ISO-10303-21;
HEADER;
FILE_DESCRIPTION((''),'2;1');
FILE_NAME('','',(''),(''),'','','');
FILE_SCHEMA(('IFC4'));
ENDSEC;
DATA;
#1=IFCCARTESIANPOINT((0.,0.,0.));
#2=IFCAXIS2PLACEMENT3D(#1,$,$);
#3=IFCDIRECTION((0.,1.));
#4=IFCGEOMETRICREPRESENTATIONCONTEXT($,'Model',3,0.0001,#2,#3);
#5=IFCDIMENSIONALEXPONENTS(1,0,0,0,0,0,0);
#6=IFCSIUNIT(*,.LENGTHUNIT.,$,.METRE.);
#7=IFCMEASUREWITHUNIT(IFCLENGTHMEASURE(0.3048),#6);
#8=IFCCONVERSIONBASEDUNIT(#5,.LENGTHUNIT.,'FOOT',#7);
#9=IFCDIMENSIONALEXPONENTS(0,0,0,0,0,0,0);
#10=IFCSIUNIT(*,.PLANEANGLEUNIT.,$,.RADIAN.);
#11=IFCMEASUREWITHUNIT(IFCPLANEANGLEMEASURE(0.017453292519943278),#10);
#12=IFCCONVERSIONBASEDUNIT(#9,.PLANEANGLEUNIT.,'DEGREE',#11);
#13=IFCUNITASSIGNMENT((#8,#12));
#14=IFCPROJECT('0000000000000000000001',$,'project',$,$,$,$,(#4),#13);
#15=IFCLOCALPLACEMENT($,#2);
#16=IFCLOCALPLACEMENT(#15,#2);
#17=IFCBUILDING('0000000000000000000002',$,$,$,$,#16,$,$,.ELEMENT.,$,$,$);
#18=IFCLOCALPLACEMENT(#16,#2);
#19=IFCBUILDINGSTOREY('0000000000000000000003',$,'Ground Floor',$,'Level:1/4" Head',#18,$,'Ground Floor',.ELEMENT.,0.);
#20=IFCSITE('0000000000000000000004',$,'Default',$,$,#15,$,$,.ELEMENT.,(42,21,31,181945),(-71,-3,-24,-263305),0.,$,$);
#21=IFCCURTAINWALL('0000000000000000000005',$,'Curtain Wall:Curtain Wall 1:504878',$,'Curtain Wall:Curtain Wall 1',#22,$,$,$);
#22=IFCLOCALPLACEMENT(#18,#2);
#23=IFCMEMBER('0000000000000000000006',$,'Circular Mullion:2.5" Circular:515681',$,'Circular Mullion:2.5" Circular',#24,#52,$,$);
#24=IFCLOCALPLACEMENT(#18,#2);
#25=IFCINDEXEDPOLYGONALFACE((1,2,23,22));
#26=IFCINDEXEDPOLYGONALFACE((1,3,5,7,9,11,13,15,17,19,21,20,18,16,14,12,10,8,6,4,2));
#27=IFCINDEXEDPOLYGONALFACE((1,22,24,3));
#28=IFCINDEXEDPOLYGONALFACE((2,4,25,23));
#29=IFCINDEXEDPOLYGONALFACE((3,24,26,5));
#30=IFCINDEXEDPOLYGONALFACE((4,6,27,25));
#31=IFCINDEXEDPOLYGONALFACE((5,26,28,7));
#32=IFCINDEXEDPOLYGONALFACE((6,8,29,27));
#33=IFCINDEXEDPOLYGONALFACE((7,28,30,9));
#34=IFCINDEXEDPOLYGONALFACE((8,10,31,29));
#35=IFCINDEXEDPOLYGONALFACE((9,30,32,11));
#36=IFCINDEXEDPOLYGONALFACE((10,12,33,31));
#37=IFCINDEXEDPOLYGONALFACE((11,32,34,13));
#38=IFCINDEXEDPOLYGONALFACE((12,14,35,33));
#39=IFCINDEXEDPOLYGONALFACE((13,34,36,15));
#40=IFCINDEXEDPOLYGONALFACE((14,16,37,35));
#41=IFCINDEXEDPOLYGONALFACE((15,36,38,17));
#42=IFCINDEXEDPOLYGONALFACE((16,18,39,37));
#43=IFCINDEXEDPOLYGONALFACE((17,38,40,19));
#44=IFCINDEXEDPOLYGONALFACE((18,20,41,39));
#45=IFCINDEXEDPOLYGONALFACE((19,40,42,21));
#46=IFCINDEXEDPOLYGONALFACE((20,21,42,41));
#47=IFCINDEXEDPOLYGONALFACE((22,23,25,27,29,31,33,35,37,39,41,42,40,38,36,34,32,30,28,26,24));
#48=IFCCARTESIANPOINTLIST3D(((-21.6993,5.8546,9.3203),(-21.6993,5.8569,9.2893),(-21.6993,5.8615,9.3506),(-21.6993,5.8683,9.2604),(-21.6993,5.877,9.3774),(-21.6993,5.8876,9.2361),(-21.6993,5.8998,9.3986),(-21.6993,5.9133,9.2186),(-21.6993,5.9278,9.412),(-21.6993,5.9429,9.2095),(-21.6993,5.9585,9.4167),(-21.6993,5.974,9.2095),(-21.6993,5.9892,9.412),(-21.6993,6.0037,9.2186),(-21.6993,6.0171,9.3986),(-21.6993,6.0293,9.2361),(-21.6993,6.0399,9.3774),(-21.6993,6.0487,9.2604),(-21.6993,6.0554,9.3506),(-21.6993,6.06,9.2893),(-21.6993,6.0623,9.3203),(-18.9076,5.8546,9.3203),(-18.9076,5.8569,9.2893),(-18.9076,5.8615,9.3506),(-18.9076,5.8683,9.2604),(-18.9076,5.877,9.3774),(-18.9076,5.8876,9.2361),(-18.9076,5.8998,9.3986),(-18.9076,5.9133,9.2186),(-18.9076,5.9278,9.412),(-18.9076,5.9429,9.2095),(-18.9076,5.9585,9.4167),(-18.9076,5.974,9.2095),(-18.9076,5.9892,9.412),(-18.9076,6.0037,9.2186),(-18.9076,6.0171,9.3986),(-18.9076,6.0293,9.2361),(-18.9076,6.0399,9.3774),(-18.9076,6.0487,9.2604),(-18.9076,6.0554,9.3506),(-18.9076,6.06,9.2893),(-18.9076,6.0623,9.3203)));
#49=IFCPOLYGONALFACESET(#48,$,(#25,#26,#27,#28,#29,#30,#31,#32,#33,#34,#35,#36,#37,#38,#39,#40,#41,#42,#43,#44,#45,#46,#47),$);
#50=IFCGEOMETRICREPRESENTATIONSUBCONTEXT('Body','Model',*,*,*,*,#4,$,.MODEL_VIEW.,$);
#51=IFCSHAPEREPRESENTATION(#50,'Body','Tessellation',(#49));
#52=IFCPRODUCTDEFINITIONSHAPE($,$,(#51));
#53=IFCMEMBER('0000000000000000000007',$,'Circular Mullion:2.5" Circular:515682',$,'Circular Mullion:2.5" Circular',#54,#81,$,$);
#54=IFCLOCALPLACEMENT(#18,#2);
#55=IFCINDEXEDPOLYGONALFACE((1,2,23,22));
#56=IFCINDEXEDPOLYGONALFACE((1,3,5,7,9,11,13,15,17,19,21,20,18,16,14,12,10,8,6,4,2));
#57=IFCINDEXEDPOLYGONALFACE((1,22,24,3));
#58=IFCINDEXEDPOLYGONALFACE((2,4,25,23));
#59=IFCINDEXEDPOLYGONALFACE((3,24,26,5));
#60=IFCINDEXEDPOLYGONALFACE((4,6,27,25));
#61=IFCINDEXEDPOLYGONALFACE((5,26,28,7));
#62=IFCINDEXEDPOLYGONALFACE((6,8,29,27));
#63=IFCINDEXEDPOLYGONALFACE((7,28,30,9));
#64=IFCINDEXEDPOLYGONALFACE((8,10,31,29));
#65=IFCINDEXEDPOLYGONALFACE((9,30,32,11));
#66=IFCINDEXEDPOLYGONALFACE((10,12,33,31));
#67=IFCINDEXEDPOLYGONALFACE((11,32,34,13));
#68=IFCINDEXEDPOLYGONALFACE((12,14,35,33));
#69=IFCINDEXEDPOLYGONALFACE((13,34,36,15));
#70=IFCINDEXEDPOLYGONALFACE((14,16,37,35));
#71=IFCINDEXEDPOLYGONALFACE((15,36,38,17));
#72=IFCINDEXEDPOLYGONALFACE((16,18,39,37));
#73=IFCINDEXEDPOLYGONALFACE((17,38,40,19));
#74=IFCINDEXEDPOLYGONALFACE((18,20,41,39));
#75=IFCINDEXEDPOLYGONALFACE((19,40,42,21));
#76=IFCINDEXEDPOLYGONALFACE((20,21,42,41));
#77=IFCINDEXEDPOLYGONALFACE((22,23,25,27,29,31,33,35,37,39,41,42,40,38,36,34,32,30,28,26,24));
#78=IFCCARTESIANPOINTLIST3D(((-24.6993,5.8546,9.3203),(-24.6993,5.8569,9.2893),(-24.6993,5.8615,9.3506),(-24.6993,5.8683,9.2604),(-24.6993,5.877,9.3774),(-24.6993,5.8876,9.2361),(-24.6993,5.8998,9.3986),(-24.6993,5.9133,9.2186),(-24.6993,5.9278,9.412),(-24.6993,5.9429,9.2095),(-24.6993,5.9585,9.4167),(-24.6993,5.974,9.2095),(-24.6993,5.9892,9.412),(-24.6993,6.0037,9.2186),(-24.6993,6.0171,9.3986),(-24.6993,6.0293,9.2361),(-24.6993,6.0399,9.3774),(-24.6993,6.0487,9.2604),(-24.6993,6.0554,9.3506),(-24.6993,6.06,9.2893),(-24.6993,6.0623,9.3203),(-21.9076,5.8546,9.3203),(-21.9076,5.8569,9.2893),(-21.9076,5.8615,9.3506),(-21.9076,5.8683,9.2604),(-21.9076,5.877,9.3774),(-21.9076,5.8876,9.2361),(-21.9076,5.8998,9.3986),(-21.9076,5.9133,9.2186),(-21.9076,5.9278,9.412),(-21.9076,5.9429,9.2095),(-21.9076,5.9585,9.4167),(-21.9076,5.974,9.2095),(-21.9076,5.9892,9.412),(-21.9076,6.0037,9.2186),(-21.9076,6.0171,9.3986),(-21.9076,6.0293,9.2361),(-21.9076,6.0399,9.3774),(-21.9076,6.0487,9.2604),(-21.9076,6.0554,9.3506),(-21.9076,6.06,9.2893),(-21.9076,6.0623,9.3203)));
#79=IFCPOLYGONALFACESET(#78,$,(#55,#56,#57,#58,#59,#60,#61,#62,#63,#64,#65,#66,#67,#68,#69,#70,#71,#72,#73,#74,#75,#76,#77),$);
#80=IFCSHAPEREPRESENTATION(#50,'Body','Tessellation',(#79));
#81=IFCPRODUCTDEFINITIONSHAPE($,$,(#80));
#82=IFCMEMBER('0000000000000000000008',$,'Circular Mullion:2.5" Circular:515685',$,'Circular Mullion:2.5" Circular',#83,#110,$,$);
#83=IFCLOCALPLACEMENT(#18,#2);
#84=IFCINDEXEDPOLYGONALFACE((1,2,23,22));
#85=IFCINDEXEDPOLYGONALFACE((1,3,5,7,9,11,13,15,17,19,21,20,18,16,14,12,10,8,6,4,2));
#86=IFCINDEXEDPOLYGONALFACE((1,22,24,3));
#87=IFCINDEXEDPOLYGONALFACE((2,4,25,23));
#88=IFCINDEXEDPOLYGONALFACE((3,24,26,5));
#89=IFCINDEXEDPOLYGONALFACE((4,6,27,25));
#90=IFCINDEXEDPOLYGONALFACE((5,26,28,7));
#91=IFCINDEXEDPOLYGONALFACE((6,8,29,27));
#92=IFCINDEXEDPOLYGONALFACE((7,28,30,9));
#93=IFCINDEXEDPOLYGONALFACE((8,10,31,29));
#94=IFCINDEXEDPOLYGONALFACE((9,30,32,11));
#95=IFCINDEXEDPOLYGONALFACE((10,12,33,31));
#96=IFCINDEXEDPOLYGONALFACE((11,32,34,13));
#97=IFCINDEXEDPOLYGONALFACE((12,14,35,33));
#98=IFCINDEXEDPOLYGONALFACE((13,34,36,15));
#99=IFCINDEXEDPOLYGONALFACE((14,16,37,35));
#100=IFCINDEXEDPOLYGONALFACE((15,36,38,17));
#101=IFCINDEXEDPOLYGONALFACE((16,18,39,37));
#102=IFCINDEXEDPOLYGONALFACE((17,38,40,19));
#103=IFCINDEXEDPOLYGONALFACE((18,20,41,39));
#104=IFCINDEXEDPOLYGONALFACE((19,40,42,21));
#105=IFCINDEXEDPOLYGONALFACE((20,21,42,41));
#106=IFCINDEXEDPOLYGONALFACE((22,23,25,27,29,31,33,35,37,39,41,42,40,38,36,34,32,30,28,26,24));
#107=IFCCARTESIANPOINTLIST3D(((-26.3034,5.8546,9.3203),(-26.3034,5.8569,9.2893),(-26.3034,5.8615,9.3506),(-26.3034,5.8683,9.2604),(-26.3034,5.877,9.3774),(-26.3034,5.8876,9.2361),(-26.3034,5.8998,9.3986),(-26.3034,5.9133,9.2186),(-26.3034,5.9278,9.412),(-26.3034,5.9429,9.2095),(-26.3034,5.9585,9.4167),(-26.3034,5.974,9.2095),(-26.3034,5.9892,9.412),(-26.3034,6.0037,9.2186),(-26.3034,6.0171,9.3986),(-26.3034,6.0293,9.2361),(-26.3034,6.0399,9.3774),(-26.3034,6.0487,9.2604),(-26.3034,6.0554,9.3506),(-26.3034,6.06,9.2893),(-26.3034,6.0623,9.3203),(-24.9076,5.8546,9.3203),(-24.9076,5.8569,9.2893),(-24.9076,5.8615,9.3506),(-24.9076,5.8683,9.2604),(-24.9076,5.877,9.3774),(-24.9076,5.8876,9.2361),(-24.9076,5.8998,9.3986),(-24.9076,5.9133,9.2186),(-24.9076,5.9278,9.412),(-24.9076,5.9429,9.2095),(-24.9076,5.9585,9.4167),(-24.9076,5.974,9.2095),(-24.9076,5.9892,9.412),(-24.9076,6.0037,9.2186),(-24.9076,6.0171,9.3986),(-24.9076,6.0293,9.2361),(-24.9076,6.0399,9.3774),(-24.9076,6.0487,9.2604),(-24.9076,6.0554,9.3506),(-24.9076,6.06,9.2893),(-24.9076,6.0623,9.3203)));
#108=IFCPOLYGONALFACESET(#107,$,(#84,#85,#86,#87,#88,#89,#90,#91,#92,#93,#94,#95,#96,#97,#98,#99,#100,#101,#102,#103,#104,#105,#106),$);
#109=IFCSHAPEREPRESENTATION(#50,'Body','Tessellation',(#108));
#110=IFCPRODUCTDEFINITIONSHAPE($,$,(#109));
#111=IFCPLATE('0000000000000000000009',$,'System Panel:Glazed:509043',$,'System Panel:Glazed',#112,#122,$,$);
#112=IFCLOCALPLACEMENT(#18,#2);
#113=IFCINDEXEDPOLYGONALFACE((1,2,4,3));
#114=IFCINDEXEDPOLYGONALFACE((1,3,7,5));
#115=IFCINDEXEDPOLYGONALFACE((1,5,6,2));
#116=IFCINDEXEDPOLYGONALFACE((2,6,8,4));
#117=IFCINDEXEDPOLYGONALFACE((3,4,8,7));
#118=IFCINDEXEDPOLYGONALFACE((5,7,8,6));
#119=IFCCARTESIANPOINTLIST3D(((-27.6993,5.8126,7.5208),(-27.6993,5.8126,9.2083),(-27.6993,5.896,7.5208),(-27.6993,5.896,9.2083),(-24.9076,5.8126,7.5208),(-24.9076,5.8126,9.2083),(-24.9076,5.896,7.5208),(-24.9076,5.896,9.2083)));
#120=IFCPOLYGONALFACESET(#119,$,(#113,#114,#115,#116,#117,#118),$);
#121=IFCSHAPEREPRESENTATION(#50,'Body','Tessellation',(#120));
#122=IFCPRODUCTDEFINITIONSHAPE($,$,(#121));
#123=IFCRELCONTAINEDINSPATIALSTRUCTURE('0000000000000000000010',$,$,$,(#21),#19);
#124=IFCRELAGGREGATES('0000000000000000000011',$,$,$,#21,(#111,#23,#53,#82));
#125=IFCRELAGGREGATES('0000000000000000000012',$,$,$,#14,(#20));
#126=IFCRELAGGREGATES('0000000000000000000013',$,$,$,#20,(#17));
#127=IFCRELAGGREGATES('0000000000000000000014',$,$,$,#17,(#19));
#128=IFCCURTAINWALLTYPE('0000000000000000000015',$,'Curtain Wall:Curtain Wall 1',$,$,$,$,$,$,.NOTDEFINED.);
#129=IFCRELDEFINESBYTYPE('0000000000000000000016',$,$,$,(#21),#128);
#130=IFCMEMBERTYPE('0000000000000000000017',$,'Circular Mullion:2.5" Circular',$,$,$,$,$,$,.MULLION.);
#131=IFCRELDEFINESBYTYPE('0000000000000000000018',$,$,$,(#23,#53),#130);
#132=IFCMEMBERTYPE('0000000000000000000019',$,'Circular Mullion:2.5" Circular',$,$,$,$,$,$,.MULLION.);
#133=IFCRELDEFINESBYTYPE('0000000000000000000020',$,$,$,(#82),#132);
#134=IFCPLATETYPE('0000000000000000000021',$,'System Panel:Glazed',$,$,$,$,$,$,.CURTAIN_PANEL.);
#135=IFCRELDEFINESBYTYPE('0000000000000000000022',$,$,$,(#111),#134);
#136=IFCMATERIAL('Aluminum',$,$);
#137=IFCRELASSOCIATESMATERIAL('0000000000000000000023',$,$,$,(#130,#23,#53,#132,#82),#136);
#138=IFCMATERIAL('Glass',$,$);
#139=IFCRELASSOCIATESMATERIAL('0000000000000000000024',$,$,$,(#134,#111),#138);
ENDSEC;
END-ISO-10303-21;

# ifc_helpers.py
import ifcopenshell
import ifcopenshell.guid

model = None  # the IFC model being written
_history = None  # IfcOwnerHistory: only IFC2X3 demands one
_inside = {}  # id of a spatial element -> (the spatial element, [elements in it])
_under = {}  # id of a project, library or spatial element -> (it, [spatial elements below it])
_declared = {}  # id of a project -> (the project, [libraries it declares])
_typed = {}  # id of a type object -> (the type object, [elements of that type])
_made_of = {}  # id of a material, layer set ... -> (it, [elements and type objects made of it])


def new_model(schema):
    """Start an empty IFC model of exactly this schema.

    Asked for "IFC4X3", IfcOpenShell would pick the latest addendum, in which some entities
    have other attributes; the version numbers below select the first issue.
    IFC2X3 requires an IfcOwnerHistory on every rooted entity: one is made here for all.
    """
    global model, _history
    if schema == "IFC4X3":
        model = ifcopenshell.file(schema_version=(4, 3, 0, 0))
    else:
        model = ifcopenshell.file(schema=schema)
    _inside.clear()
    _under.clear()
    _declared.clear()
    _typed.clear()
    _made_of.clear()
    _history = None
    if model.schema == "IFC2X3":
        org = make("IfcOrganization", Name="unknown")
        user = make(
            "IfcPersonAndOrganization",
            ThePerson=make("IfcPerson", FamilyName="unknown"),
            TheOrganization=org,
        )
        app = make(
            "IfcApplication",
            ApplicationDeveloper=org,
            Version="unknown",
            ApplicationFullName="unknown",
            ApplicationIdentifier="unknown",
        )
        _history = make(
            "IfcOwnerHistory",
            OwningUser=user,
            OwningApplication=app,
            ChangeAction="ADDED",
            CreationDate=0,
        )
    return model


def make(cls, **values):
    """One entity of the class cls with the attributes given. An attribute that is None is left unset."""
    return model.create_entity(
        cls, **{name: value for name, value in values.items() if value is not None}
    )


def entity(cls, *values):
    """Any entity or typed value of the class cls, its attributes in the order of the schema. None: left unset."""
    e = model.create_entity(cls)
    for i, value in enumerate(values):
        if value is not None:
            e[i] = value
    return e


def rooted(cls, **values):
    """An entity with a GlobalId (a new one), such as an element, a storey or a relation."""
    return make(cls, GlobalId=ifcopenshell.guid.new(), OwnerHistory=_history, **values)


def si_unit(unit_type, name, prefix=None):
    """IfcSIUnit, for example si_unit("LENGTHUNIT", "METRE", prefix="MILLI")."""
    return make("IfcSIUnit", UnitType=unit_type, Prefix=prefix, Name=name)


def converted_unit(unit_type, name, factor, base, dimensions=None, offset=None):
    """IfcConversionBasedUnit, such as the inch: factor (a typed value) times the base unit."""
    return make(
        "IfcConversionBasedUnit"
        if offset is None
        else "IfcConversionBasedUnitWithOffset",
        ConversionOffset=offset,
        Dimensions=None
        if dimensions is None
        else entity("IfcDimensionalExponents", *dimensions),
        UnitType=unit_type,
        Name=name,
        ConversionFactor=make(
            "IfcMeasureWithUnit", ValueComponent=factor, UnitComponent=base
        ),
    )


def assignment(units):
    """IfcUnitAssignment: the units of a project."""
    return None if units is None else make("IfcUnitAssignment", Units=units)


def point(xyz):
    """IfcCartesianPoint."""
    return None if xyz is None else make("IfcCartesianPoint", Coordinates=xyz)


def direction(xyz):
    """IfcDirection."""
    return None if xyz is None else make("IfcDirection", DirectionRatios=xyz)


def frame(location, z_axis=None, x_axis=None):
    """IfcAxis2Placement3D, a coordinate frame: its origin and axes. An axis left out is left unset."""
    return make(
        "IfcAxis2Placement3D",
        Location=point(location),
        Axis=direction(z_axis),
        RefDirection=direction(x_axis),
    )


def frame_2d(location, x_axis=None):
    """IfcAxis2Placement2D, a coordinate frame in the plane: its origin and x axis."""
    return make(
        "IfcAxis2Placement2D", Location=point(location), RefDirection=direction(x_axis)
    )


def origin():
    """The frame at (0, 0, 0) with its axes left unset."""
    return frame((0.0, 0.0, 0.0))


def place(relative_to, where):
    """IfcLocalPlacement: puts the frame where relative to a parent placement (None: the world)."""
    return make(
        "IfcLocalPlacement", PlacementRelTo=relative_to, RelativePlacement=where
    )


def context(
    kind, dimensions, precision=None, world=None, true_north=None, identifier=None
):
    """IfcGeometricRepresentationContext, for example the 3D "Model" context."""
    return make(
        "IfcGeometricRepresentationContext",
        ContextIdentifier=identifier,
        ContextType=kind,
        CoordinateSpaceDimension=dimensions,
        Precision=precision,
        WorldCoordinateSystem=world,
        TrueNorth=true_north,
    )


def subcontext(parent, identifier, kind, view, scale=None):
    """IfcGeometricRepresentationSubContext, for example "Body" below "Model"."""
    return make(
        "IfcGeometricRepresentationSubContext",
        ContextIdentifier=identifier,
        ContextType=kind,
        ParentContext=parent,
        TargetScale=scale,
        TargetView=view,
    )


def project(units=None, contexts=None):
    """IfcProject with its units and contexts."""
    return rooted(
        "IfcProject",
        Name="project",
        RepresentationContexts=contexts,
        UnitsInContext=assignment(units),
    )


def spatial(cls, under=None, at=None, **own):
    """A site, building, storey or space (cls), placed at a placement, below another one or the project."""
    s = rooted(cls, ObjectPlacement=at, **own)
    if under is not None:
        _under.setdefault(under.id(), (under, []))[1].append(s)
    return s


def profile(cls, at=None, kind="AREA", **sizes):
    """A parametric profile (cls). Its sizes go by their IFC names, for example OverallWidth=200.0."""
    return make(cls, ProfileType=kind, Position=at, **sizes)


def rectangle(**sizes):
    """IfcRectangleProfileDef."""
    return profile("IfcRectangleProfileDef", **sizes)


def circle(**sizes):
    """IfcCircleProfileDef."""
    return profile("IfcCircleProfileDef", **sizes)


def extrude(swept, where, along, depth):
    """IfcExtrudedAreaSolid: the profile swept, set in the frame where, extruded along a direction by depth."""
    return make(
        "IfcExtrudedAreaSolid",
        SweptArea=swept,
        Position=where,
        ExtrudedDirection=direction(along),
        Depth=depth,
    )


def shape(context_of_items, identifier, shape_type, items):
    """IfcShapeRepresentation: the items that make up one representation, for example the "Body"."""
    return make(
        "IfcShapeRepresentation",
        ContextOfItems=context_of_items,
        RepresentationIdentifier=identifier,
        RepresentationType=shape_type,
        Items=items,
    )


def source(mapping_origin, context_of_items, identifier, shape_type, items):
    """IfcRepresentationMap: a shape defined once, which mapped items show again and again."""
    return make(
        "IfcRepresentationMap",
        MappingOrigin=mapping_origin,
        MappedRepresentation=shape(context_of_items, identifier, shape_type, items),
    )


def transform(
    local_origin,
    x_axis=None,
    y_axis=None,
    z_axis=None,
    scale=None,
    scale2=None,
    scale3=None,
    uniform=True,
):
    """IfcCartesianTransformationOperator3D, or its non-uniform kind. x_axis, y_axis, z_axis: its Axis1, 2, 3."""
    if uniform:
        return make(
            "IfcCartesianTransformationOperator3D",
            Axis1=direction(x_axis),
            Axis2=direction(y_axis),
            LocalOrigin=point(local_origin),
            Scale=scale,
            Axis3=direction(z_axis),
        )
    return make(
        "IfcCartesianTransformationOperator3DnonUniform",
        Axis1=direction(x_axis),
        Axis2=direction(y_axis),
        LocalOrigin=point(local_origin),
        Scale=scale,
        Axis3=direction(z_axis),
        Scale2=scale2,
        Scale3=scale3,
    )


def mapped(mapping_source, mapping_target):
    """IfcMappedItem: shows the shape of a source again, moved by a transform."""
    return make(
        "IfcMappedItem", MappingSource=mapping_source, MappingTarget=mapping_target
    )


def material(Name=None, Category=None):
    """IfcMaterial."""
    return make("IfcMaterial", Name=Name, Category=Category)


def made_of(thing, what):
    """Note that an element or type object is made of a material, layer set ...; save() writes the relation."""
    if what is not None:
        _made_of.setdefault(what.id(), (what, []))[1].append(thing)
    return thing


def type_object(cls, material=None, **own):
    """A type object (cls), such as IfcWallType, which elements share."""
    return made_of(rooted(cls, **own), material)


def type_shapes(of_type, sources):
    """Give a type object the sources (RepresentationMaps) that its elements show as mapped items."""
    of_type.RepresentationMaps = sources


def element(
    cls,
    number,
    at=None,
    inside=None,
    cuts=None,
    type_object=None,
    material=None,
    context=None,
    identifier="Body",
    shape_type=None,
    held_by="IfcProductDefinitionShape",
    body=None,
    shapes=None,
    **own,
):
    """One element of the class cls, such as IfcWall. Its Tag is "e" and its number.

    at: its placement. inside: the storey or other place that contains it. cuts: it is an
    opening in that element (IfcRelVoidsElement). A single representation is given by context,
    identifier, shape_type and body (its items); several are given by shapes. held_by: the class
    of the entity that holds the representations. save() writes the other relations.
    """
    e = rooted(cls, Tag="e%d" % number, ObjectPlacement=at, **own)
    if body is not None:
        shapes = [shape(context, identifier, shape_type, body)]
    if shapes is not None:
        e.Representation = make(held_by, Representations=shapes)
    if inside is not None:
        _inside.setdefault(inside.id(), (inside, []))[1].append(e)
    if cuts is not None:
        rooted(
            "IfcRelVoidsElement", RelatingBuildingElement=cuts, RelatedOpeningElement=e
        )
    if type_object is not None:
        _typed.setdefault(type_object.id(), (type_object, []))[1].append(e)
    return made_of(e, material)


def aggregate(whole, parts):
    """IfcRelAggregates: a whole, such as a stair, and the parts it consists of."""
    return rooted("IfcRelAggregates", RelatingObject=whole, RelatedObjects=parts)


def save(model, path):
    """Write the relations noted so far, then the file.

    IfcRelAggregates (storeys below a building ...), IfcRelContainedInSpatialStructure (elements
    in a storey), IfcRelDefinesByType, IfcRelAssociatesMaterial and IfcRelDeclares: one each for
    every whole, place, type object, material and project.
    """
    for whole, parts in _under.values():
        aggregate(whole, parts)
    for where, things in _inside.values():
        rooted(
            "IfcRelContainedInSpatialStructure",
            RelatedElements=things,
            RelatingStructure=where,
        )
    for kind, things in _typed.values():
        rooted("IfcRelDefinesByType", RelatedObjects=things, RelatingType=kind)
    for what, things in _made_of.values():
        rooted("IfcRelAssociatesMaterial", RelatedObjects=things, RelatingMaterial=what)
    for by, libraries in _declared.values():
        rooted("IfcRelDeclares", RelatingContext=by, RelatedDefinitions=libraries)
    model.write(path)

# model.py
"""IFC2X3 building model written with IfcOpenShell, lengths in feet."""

from ifc_helpers import new_model, entity, si_unit, converted_unit, direction, frame, frame_2d, origin, place, context, subcontext, project, spatial, rectangle, circle, extrude, source, transform, mapped, material, type_object, type_shapes, element, aggregate, save


model = new_model("IFC2X3")

# Units and contexts
model_context = context("Model", 3, precision=0.0001, world=origin(), true_north=direction((0.0, 1.0)))
body_context = subcontext(model_context, "Body", "Model", "MODEL_VIEW")
ifc_project = project(units=[converted_unit("LENGTHUNIT", "FOOT", entity("IfcLengthMeasure", 0.3048), si_unit("LENGTHUNIT", "METRE"), dimensions=[1, 0, 0, 0, 0, 0, 0]), converted_unit("PLANEANGLEUNIT", "DEGREE", entity("IfcPlaneAngleMeasure", 0.017453292519943278), si_unit("PLANEANGLEUNIT", "RADIAN"), dimensions=[0, 0, 0, 0, 0, 0, 0])], contexts=[model_context])

# Site, building, storey
site_placement = place(None, origin())
site = spatial("IfcSite", under=ifc_project, at=site_placement, Name="Default", CompositionType="ELEMENT", RefLatitude=(42, 21, 31, 181945), RefLongitude=(-71, -3, -24, -263305), RefElevation=0.0)
building_placement = place(site_placement, origin())
building = spatial("IfcBuilding", under=site, at=building_placement, CompositionType="ELEMENT")
storey_placement = place(building_placement, origin())
storey = spatial("IfcBuildingStorey", under=building, at=storey_placement, Name="Ground Floor", ObjectType="Level:1/4\" Head", LongName="Ground Floor", CompositionType="ELEMENT", Elevation=0.0)

# Curtain wall, members, plate
curtain_wall_type = type_object("IfcCurtainWallType", Name="Curtain Wall:Curtain Wall 1", PredefinedType="NOTDEFINED")
curtain_wall_placement = place(storey_placement, origin())
curtain_wall = element("IfcCurtainWall", 1, at=curtain_wall_placement, inside=storey, type_object=curtain_wall_type, Name="Curtain Wall:Curtain Wall 1:504878", ObjectType="Curtain Wall:Curtain Wall 1")
ifc_material_1 = material(Name="Aluminum")
member_type_1 = type_object("IfcMemberType", Name="Circular Mullion:2.5\" Circular", PredefinedType="MULLION", material=ifc_material_1)
shared_shape_1 = source(origin(), body_context, "Body", "SweptSolid", [
    extrude(circle(Radius=0.1042, at=frame_2d((0.0, 0.0), x_axis=(1.0, 0.0))), frame((-0.1042, 0.0, -2.7917)), (0.0, 0.0, 1.0), 2.7917),
])
type_shapes(member_type_1, [shared_shape_1])
member_1_placement = place(curtain_wall_placement, frame((-21.6993, 5.9585, 9.4167), z_axis=(-1.0, 0.0, 0.0), x_axis=(0.0, 0.0, 1.0)))
member_1 = element("IfcMember", 2, at=member_1_placement, type_object=member_type_1, material=ifc_material_1, Name="Circular Mullion:2.5\" Circular:515681", ObjectType="Circular Mullion:2.5\" Circular", context=body_context, shape_type="MappedRepresentation", body=[
    mapped(shared_shape_1, transform((0.0, 0.0, 0.0), scale=1.0)),
])
member_2_placement = place(curtain_wall_placement, frame((-24.6993, 5.9585, 9.4167), z_axis=(-1.0, 0.0, 0.0), x_axis=(0.0, 0.0, 1.0)))
member_2 = element("IfcMember", 3, at=member_2_placement, type_object=member_type_1, material=ifc_material_1, Name="Circular Mullion:2.5\" Circular:515682", ObjectType="Circular Mullion:2.5\" Circular", context=body_context, shape_type="MappedRepresentation", body=[
    mapped(shared_shape_1, transform((0.0, 0.0, 0.0), scale=1.0)),
])
member_type_2 = type_object("IfcMemberType", Name="Circular Mullion:2.5\" Circular", PredefinedType="MULLION", material=ifc_material_1)
shared_shape_2 = source(origin(), body_context, "Body", "SweptSolid", [
    extrude(circle(Radius=0.1042, at=frame_2d((0.0, 0.0), x_axis=(1.0, 0.0))), frame((-0.1042, 0.0, -1.3958)), (0.0, 0.0, 1.0), 1.3958),
])
type_shapes(member_type_2, [shared_shape_2])
member_3_placement = place(curtain_wall_placement, frame((-26.3034, 5.9585, 9.4167), z_axis=(-1.0, 0.0, 0.0), x_axis=(0.0, 0.0, 1.0)))
member_3 = element("IfcMember", 4, at=member_3_placement, type_object=member_type_2, material=ifc_material_1, Name="Circular Mullion:2.5\" Circular:515685", ObjectType="Circular Mullion:2.5\" Circular", context=body_context, shape_type="MappedRepresentation", body=[
    mapped(shared_shape_2, transform((0.0, 0.0, 0.0), scale=1.0)),
])
ifc_material_2 = material(Name="Glass")
plate_type_1 = type_object("IfcPlateType", Name="System Panel:Glazed", PredefinedType="CURTAIN_PANEL", material=ifc_material_2)
shared_shape_3 = source(origin(), body_context, "Body", "SweptSolid", [
    extrude(rectangle(XDim=1.6875, YDim=2.7917, at=frame_2d((0.0, 0.0), x_axis=(1.0, 0.0))), frame((0.0, 0.0625, 0.8437), z_axis=(0.0, 1.0, 0.0), x_axis=(0.0, 0.0, 1.0)), (0.0, 0.0, 1.0), 0.0833),
])
type_shapes(plate_type_1, [shared_shape_3])
plate_1_placement = place(curtain_wall_placement, frame((-26.3034, 5.9585, 7.5208), z_axis=(0.0, 0.0, 1.0), x_axis=(-1.0, 0.0, 0.0)))
plate_1 = element("IfcPlate", 5, at=plate_1_placement, type_object=plate_type_1, material=ifc_material_2, Name="System Panel:Glazed:509043", ObjectType="System Panel:Glazed", context=body_context, shape_type="MappedRepresentation", body=[
    mapped(shared_shape_3, transform((0.0, 0.0, 0.0), scale=1.0)),
])
aggregate(curtain_wall, [plate_1, member_1, member_2, member_3])

save(model, "model.ifc")
